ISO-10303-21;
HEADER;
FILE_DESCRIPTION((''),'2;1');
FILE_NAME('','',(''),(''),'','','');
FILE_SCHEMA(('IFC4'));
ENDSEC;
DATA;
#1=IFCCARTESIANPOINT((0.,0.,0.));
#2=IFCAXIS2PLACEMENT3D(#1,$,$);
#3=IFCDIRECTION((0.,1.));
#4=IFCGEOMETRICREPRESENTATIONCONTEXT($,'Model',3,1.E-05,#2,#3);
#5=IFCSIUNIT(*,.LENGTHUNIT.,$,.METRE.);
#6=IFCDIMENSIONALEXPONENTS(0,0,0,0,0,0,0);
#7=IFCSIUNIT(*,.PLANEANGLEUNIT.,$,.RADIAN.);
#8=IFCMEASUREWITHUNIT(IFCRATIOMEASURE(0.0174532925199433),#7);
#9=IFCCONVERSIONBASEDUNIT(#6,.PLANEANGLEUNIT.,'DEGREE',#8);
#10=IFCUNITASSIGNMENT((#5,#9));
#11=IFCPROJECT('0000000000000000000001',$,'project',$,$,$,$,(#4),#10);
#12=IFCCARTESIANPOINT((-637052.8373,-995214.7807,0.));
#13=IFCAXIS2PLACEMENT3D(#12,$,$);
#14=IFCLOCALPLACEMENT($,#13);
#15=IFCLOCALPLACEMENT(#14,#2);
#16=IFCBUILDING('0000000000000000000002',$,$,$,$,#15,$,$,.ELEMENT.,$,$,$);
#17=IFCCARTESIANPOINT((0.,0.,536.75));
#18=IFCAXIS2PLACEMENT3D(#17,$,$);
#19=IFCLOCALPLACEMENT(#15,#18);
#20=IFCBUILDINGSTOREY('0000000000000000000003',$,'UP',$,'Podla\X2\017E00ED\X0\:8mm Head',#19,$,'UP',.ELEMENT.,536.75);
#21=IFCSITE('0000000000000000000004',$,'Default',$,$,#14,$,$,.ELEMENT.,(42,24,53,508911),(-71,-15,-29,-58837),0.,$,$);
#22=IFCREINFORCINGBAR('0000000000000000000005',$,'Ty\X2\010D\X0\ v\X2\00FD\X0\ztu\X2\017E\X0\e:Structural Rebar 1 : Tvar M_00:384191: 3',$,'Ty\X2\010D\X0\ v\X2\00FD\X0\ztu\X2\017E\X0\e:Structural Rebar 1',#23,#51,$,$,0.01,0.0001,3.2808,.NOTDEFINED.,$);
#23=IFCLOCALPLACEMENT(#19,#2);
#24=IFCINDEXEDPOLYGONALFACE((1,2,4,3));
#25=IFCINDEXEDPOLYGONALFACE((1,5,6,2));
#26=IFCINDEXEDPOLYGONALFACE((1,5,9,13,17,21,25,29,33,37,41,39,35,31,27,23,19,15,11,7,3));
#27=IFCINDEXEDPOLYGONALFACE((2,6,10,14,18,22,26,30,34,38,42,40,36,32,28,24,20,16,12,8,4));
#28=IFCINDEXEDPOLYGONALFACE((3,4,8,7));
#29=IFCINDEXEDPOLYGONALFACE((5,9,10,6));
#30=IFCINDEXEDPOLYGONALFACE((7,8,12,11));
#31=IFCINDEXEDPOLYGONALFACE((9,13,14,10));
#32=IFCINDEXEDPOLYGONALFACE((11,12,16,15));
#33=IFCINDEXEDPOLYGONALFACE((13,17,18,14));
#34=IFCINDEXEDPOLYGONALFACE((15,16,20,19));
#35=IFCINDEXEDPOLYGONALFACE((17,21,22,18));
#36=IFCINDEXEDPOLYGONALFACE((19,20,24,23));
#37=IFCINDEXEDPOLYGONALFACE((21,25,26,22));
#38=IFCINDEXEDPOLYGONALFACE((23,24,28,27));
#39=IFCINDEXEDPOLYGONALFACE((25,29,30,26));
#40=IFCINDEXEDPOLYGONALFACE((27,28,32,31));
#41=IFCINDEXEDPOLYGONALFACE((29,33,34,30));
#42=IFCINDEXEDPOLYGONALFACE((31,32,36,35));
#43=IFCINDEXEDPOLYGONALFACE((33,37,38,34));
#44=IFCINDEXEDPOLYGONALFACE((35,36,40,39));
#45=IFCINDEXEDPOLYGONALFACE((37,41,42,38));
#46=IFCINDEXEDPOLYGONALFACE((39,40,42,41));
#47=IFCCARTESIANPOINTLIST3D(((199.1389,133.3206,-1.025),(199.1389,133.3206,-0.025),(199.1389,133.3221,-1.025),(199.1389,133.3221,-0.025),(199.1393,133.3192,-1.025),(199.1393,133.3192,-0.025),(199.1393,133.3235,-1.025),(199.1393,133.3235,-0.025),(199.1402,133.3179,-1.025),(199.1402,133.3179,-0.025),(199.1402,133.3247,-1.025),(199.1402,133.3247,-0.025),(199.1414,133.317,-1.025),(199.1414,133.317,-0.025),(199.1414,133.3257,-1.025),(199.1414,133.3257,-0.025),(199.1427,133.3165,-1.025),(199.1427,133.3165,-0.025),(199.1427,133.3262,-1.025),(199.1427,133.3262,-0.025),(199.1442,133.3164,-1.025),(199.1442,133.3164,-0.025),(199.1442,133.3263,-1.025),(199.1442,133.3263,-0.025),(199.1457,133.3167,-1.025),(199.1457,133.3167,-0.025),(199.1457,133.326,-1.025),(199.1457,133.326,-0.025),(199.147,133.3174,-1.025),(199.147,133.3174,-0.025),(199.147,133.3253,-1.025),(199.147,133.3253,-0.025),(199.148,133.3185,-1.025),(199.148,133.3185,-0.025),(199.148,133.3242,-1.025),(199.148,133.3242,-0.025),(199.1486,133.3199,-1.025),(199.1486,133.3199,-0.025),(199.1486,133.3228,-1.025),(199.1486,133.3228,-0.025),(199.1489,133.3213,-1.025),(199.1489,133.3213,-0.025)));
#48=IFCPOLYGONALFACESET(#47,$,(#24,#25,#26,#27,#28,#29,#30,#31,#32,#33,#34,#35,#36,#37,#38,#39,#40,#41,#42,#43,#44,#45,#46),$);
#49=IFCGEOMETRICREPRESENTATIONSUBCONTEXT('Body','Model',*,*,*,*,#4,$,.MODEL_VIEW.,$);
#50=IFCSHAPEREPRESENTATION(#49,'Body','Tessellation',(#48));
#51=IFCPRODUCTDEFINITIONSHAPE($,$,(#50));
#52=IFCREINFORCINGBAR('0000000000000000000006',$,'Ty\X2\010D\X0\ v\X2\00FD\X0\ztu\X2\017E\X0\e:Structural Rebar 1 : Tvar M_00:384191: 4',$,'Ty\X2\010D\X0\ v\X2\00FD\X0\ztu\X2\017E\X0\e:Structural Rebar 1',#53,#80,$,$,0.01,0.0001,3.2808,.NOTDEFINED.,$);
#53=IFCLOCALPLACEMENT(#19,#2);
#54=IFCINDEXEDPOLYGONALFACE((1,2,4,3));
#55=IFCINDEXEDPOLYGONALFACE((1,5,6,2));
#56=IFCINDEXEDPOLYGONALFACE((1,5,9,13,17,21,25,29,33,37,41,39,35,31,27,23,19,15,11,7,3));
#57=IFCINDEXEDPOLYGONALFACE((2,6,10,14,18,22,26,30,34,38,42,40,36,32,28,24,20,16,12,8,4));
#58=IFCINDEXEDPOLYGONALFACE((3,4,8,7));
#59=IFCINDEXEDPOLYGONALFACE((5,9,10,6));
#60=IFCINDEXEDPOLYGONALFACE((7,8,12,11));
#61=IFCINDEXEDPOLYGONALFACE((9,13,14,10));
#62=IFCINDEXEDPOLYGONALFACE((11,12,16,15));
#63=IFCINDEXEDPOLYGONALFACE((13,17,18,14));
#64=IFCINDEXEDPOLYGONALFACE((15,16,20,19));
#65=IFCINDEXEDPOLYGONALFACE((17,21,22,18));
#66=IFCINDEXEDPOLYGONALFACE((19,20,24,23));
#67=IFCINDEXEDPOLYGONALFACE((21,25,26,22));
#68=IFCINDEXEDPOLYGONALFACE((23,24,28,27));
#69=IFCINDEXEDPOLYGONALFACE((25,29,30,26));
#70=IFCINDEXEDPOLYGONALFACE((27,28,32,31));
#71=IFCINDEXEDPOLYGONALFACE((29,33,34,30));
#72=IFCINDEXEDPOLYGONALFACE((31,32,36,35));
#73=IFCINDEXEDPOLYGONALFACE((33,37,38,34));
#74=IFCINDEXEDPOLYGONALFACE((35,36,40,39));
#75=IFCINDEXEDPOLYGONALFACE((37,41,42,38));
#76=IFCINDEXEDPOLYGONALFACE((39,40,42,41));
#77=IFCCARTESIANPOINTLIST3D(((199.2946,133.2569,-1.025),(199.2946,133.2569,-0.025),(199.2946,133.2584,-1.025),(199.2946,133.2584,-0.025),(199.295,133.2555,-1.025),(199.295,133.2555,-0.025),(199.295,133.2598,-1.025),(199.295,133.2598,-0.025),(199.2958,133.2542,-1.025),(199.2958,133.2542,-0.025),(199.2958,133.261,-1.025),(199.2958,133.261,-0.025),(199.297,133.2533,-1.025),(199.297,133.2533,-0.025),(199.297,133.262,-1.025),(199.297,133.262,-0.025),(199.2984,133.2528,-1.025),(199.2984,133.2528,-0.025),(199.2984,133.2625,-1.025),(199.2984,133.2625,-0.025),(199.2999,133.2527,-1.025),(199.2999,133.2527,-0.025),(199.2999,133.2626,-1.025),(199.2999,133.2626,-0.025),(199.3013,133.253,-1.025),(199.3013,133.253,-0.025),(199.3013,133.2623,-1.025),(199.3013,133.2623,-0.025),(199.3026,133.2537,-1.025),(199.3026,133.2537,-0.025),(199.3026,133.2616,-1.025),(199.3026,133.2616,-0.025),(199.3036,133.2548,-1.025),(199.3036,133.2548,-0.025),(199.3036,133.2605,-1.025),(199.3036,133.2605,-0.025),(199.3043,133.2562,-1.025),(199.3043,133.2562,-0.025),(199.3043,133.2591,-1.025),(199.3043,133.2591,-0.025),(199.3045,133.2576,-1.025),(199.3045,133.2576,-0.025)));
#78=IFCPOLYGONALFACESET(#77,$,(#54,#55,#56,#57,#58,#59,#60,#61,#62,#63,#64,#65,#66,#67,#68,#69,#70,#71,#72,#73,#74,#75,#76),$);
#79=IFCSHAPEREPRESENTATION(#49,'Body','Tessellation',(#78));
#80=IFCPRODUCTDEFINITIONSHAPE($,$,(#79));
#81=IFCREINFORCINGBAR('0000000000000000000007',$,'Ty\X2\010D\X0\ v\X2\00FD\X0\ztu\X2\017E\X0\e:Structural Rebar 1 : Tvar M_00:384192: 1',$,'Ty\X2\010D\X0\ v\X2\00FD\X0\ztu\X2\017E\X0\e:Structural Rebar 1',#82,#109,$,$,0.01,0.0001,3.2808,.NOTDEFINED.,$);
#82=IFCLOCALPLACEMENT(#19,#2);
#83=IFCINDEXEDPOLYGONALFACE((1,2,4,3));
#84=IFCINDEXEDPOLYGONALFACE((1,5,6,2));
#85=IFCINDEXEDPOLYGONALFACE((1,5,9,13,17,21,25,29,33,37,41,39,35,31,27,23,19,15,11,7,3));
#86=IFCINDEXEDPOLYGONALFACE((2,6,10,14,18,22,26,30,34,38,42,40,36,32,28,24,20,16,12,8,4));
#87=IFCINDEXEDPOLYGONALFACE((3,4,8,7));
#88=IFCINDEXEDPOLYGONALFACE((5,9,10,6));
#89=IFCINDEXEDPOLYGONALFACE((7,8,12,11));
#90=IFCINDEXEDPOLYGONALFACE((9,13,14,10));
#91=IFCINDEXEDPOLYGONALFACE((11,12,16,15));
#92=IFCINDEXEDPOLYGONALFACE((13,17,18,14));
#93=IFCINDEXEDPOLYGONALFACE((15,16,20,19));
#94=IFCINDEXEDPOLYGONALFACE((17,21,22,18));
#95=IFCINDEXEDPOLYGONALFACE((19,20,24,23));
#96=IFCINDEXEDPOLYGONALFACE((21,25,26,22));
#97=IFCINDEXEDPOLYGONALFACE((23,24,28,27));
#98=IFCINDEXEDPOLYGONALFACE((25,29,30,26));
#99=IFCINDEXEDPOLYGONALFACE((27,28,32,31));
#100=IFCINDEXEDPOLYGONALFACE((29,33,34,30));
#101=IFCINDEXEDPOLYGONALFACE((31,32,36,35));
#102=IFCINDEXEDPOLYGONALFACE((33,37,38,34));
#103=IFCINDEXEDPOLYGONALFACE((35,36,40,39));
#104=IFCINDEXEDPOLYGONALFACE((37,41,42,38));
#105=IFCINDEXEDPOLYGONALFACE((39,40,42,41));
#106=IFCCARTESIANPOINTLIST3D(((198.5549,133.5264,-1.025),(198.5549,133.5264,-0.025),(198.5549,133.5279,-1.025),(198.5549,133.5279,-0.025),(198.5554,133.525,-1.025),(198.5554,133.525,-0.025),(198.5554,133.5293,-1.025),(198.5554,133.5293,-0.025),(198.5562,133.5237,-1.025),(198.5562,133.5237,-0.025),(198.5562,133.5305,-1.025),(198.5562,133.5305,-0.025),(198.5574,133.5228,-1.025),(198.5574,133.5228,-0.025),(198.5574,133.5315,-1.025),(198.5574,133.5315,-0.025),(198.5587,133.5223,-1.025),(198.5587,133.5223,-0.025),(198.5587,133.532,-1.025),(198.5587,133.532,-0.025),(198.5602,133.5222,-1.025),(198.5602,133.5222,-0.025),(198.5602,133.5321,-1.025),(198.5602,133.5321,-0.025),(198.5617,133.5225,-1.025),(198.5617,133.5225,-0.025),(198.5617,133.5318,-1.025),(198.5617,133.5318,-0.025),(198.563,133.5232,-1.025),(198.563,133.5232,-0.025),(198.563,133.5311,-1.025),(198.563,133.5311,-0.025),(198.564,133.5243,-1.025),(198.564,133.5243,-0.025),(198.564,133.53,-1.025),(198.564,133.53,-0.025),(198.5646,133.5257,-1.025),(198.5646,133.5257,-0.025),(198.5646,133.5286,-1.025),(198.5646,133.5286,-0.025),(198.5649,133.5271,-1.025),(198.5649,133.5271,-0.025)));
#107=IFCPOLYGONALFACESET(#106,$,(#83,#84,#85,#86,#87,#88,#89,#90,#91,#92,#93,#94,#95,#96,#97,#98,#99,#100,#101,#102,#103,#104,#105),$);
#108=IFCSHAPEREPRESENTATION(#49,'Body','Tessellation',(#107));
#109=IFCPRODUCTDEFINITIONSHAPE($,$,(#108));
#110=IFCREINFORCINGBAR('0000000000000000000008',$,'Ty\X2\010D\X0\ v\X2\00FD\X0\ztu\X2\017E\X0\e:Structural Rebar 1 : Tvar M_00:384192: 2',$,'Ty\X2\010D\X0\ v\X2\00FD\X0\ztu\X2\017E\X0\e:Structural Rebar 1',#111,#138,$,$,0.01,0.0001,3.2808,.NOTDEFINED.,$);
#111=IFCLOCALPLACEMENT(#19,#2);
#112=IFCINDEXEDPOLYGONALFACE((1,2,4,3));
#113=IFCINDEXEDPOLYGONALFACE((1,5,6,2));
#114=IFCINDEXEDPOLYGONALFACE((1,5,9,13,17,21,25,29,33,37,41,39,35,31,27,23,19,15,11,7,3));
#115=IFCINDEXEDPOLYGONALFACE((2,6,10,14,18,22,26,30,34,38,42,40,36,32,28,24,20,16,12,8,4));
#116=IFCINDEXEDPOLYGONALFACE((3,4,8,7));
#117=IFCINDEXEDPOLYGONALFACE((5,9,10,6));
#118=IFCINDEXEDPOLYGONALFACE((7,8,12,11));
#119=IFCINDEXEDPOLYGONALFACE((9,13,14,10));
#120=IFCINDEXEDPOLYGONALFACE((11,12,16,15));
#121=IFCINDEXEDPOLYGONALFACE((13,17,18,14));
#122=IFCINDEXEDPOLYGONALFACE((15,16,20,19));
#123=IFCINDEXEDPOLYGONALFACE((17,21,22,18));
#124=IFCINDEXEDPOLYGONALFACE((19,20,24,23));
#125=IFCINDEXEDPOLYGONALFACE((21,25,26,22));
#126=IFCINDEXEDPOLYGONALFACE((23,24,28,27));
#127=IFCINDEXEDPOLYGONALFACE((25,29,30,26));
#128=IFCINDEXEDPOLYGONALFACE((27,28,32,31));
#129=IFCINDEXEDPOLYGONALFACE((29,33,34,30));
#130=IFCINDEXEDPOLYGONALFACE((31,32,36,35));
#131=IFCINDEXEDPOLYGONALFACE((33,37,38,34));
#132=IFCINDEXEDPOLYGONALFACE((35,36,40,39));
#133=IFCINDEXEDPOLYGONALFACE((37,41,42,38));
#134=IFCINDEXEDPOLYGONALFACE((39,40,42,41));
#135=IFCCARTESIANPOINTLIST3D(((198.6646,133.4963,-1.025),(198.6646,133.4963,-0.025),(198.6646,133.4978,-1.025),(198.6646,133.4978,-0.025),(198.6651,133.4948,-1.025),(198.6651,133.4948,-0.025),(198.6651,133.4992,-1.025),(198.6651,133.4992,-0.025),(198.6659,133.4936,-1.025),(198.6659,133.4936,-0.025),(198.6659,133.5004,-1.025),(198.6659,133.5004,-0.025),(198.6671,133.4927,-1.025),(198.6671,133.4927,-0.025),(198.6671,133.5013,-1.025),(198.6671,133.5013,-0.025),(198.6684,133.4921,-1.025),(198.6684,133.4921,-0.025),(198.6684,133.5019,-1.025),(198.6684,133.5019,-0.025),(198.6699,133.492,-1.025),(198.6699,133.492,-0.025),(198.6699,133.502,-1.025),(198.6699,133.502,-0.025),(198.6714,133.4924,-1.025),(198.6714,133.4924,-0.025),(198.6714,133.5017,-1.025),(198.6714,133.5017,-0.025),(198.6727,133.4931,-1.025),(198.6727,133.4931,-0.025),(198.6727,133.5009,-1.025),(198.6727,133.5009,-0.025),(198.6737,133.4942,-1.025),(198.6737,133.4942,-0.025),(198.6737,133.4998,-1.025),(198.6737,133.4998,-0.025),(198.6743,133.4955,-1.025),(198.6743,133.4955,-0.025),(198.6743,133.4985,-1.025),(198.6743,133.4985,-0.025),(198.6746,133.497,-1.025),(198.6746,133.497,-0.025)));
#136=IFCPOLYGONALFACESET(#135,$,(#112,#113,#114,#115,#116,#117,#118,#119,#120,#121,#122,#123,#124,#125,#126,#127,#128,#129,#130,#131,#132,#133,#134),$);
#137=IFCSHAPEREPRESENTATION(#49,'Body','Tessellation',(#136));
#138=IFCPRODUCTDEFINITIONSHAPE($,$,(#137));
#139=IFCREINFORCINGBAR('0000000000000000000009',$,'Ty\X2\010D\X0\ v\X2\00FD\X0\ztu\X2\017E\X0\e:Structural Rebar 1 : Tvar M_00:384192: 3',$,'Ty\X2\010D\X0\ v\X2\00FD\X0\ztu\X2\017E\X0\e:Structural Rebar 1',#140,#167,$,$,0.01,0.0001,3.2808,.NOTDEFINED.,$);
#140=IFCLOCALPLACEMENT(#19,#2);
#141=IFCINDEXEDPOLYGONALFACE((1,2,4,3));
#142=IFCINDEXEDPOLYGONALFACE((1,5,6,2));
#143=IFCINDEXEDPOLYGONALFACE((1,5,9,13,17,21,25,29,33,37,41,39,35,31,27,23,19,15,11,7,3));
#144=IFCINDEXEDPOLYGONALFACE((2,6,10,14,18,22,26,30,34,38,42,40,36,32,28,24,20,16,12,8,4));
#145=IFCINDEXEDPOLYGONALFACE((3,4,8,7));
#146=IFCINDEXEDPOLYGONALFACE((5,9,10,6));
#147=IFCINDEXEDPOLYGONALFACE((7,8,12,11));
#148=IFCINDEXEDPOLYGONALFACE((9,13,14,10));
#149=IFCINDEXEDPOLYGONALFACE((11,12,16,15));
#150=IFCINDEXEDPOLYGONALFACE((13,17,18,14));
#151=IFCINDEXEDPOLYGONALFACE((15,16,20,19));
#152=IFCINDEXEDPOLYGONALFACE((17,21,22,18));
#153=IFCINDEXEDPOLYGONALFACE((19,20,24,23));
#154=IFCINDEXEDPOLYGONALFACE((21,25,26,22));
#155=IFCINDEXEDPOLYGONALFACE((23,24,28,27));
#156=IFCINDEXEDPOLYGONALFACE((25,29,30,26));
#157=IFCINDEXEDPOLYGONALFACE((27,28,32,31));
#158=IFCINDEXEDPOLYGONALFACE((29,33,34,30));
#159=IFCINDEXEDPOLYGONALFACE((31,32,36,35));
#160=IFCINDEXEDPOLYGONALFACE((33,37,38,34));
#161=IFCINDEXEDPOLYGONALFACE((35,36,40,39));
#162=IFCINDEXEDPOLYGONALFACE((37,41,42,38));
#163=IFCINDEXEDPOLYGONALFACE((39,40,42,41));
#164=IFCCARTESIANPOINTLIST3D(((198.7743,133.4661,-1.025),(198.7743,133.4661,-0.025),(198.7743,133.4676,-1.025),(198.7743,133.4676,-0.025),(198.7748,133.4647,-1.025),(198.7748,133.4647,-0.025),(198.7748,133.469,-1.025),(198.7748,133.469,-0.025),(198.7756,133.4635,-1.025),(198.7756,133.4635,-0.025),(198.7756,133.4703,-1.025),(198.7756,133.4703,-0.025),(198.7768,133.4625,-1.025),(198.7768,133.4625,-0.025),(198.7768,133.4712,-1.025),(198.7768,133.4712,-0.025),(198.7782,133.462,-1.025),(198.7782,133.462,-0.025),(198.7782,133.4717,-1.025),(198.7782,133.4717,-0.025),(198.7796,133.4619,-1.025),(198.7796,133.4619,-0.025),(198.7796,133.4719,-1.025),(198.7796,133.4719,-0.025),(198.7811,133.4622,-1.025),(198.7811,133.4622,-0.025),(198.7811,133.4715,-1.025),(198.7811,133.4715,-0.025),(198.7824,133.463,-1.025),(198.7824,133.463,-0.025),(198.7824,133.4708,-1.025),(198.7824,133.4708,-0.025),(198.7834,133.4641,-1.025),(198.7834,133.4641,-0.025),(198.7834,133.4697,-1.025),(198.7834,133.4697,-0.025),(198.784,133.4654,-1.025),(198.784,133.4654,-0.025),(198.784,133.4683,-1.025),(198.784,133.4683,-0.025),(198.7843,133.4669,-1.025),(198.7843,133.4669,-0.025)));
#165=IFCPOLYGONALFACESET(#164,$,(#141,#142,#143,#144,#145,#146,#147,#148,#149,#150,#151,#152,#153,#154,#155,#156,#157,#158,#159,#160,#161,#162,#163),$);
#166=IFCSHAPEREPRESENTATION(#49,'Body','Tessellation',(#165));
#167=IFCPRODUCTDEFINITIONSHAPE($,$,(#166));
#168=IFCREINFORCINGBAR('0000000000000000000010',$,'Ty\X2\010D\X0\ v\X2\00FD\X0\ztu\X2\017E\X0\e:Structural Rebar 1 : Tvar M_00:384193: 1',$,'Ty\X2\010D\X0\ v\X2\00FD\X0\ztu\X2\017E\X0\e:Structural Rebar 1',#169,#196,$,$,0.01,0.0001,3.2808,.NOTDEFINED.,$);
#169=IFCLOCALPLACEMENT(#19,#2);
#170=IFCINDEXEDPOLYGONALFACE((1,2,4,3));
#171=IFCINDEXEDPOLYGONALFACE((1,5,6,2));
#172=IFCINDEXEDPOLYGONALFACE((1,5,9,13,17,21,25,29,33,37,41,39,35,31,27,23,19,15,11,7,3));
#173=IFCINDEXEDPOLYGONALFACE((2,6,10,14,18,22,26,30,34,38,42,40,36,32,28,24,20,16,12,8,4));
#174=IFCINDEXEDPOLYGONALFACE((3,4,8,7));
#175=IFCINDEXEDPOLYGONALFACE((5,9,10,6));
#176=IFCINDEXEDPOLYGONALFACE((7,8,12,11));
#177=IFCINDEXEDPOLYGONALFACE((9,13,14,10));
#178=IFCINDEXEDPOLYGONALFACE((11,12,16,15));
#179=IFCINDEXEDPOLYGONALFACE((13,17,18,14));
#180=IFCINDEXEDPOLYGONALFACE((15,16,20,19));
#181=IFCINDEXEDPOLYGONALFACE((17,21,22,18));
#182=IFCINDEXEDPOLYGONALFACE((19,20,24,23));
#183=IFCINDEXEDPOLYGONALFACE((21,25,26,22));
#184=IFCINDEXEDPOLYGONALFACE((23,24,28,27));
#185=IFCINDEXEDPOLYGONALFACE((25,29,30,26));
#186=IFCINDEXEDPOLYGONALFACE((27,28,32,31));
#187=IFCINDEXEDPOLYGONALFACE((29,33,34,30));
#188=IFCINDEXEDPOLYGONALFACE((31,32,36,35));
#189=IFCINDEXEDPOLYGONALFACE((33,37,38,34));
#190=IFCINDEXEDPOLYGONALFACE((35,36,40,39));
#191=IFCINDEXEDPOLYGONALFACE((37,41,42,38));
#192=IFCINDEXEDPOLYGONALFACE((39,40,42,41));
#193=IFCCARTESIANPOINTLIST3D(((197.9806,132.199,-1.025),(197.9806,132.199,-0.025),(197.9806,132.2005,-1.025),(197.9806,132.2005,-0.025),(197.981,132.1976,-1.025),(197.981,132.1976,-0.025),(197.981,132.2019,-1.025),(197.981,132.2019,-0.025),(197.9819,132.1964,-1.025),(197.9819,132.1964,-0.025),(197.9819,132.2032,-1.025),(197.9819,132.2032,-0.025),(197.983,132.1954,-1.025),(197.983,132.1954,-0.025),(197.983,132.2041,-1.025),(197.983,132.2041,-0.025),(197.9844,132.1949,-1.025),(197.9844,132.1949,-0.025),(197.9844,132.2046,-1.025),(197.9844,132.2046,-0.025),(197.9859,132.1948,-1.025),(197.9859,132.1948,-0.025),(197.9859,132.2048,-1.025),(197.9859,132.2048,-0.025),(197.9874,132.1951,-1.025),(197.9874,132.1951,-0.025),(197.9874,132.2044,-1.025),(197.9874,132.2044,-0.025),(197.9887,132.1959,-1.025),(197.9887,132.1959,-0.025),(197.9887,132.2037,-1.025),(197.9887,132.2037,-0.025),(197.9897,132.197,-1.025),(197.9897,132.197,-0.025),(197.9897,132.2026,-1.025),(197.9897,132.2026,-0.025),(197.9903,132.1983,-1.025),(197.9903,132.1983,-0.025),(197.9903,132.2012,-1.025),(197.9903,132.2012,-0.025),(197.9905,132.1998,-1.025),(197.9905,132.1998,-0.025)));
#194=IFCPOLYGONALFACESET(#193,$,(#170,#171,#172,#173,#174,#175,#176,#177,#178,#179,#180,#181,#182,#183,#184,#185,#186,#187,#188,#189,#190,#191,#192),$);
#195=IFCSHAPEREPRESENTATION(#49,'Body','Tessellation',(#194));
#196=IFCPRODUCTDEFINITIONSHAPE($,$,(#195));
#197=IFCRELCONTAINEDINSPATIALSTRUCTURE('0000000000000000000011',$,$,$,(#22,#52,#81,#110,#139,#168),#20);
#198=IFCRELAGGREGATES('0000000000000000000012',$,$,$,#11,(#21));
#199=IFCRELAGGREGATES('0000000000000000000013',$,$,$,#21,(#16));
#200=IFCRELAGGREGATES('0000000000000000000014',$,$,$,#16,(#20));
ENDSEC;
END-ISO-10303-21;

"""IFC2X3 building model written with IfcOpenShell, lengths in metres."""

from ifc_helpers import new_model, entity, si_unit, converted_unit, direction, frame, origin, place, context, subcontext, project, spatial, element, save


model = new_model("IFC2X3")

# Units and contexts
model_context = context("Model", 3, precision=1e-05, world=origin(), true_north=direction((0.0, 1.0)))
body_context = subcontext(model_context, "Body", "Model", "MODEL_VIEW")
ifc_project = project(units=[si_unit("LENGTHUNIT", "METRE"), converted_unit("PLANEANGLEUNIT", "DEGREE", entity("IfcRatioMeasure", 0.0174532925199433), si_unit("PLANEANGLEUNIT", "RADIAN"), dimensions=[0, 0, 0, 0, 0, 0, 0])], contexts=[model_context])

# Site, building, storey
site_placement = place(None, frame((-637052.8373, -995214.7807, 0.0)))
site = spatial("IfcSite", under=ifc_project, at=site_placement, Name="Default", CompositionType="ELEMENT", RefLatitude=(42, 24, 53, 508911), RefLongitude=(-71, -15, -29, -58837), RefElevation=0.0)
building_placement = place(site_placement, origin())
building = spatial("IfcBuilding", under=site, at=building_placement, CompositionType="ELEMENT")
storey_placement = place(building_placement, frame((0.0, 0.0, 536.75)))
storey = spatial("IfcBuildingStorey", under=building, at=storey_placement, Name="UP", ObjectType="Podlaží:8mm Head", LongName="UP", CompositionType="ELEMENT", Elevation=536.75)

# Reinforcing bars
reinforcing_bar_1_placement = place(storey_placement, origin())
element("IfcReinforcingBar", 1, at=reinforcing_bar_1_placement, inside=storey, Name="Tyč výztuže:Structural Rebar 1 : Tvar M_00:384191: 3", ObjectType="Tyč výztuže:Structural Rebar 1", BarLength=3.2808, BarRole="NOTDEFINED", CrossSectionArea=0.0001, NominalDiameter=0.01, context=body_context, shape_type="AdvancedSweptSolid", body=[
    entity("IfcSweptDiskSolid", entity("IfcCompositeCurve", [entity("IfcCompositeCurveSegment", "CONTINUOUS", True, entity("IfcPolyline", [entity("IfcCartesianPoint", [-199.1439, -133.3213, 0.025]), entity("IfcCartesianPoint", [-199.1439, -133.3213, 1.025])]))], False), 0.005, None, 0.0, 1.0),
])
reinforcing_bar_2_placement = place(storey_placement, origin())
element("IfcReinforcingBar", 2, at=reinforcing_bar_2_placement, inside=storey, Name="Tyč výztuže:Structural Rebar 1 : Tvar M_00:384191: 4", ObjectType="Tyč výztuže:Structural Rebar 1", BarLength=3.2808, BarRole="NOTDEFINED", CrossSectionArea=0.0001, NominalDiameter=0.01, context=body_context, shape_type="AdvancedSweptSolid", body=[
    entity("IfcSweptDiskSolid", entity("IfcCompositeCurve", [entity("IfcCompositeCurveSegment", "CONTINUOUS", True, entity("IfcPolyline", [entity("IfcCartesianPoint", [-199.2995, -133.2576, 0.025]), entity("IfcCartesianPoint", [-199.2995, -133.2576, 1.025])]))], False), 0.005, None, 0.0, 1.0),
])
reinforcing_bar_3_placement = place(storey_placement, origin())
element("IfcReinforcingBar", 3, at=reinforcing_bar_3_placement, inside=storey, Name="Tyč výztuže:Structural Rebar 1 : Tvar M_00:384192: 1", ObjectType="Tyč výztuže:Structural Rebar 1", BarLength=3.2808, BarRole="NOTDEFINED", CrossSectionArea=0.0001, NominalDiameter=0.01, context=body_context, shape_type="AdvancedSweptSolid", body=[
    entity("IfcSweptDiskSolid", entity("IfcCompositeCurve", [entity("IfcCompositeCurveSegment", "CONTINUOUS", True, entity("IfcPolyline", [entity("IfcCartesianPoint", [-198.5599, -133.5271, 0.025]), entity("IfcCartesianPoint", [-198.5599, -133.5271, 1.025])]))], False), 0.005, None, 0.0, 1.0),
])
reinforcing_bar_4_placement = place(storey_placement, origin())
element("IfcReinforcingBar", 4, at=reinforcing_bar_4_placement, inside=storey, Name="Tyč výztuže:Structural Rebar 1 : Tvar M_00:384192: 2", ObjectType="Tyč výztuže:Structural Rebar 1", BarLength=3.2808, BarRole="NOTDEFINED", CrossSectionArea=0.0001, NominalDiameter=0.01, context=body_context, shape_type="AdvancedSweptSolid", body=[
    entity("IfcSweptDiskSolid", entity("IfcCompositeCurve", [entity("IfcCompositeCurveSegment", "CONTINUOUS", True, entity("IfcPolyline", [entity("IfcCartesianPoint", [-198.6696, -133.497, 0.025]), entity("IfcCartesianPoint", [-198.6696, -133.497, 1.025])]))], False), 0.005, None, 0.0, 1.0),
])
reinforcing_bar_5_placement = place(storey_placement, origin())
element("IfcReinforcingBar", 5, at=reinforcing_bar_5_placement, inside=storey, Name="Tyč výztuže:Structural Rebar 1 : Tvar M_00:384192: 3", ObjectType="Tyč výztuže:Structural Rebar 1", BarLength=3.2808, BarRole="NOTDEFINED", CrossSectionArea=0.0001, NominalDiameter=0.01, context=body_context, shape_type="AdvancedSweptSolid", body=[
    entity("IfcSweptDiskSolid", entity("IfcCompositeCurve", [entity("IfcCompositeCurveSegment", "CONTINUOUS", True, entity("IfcPolyline", [entity("IfcCartesianPoint", [-198.7793, -133.4669, 0.025]), entity("IfcCartesianPoint", [-198.7793, -133.4669, 1.025])]))], False), 0.005, None, 0.0, 1.0),
])
reinforcing_bar_6_placement = place(storey_placement, origin())
element("IfcReinforcingBar", 6, at=reinforcing_bar_6_placement, inside=storey, Name="Tyč výztuže:Structural Rebar 1 : Tvar M_00:384193: 1", ObjectType="Tyč výztuže:Structural Rebar 1", BarLength=3.2808, BarRole="NOTDEFINED", CrossSectionArea=0.0001, NominalDiameter=0.01, context=body_context, shape_type="AdvancedSweptSolid", body=[
    entity("IfcSweptDiskSolid", entity("IfcCompositeCurve", [entity("IfcCompositeCurveSegment", "CONTINUOUS", True, entity("IfcPolyline", [entity("IfcCartesianPoint", [-197.9855, -132.1998, 0.025]), entity("IfcCartesianPoint", [-197.9855, -132.1998, 1.025])]))], False), 0.005, None, 0.0, 1.0),
])

save(model, "model.ifc")
